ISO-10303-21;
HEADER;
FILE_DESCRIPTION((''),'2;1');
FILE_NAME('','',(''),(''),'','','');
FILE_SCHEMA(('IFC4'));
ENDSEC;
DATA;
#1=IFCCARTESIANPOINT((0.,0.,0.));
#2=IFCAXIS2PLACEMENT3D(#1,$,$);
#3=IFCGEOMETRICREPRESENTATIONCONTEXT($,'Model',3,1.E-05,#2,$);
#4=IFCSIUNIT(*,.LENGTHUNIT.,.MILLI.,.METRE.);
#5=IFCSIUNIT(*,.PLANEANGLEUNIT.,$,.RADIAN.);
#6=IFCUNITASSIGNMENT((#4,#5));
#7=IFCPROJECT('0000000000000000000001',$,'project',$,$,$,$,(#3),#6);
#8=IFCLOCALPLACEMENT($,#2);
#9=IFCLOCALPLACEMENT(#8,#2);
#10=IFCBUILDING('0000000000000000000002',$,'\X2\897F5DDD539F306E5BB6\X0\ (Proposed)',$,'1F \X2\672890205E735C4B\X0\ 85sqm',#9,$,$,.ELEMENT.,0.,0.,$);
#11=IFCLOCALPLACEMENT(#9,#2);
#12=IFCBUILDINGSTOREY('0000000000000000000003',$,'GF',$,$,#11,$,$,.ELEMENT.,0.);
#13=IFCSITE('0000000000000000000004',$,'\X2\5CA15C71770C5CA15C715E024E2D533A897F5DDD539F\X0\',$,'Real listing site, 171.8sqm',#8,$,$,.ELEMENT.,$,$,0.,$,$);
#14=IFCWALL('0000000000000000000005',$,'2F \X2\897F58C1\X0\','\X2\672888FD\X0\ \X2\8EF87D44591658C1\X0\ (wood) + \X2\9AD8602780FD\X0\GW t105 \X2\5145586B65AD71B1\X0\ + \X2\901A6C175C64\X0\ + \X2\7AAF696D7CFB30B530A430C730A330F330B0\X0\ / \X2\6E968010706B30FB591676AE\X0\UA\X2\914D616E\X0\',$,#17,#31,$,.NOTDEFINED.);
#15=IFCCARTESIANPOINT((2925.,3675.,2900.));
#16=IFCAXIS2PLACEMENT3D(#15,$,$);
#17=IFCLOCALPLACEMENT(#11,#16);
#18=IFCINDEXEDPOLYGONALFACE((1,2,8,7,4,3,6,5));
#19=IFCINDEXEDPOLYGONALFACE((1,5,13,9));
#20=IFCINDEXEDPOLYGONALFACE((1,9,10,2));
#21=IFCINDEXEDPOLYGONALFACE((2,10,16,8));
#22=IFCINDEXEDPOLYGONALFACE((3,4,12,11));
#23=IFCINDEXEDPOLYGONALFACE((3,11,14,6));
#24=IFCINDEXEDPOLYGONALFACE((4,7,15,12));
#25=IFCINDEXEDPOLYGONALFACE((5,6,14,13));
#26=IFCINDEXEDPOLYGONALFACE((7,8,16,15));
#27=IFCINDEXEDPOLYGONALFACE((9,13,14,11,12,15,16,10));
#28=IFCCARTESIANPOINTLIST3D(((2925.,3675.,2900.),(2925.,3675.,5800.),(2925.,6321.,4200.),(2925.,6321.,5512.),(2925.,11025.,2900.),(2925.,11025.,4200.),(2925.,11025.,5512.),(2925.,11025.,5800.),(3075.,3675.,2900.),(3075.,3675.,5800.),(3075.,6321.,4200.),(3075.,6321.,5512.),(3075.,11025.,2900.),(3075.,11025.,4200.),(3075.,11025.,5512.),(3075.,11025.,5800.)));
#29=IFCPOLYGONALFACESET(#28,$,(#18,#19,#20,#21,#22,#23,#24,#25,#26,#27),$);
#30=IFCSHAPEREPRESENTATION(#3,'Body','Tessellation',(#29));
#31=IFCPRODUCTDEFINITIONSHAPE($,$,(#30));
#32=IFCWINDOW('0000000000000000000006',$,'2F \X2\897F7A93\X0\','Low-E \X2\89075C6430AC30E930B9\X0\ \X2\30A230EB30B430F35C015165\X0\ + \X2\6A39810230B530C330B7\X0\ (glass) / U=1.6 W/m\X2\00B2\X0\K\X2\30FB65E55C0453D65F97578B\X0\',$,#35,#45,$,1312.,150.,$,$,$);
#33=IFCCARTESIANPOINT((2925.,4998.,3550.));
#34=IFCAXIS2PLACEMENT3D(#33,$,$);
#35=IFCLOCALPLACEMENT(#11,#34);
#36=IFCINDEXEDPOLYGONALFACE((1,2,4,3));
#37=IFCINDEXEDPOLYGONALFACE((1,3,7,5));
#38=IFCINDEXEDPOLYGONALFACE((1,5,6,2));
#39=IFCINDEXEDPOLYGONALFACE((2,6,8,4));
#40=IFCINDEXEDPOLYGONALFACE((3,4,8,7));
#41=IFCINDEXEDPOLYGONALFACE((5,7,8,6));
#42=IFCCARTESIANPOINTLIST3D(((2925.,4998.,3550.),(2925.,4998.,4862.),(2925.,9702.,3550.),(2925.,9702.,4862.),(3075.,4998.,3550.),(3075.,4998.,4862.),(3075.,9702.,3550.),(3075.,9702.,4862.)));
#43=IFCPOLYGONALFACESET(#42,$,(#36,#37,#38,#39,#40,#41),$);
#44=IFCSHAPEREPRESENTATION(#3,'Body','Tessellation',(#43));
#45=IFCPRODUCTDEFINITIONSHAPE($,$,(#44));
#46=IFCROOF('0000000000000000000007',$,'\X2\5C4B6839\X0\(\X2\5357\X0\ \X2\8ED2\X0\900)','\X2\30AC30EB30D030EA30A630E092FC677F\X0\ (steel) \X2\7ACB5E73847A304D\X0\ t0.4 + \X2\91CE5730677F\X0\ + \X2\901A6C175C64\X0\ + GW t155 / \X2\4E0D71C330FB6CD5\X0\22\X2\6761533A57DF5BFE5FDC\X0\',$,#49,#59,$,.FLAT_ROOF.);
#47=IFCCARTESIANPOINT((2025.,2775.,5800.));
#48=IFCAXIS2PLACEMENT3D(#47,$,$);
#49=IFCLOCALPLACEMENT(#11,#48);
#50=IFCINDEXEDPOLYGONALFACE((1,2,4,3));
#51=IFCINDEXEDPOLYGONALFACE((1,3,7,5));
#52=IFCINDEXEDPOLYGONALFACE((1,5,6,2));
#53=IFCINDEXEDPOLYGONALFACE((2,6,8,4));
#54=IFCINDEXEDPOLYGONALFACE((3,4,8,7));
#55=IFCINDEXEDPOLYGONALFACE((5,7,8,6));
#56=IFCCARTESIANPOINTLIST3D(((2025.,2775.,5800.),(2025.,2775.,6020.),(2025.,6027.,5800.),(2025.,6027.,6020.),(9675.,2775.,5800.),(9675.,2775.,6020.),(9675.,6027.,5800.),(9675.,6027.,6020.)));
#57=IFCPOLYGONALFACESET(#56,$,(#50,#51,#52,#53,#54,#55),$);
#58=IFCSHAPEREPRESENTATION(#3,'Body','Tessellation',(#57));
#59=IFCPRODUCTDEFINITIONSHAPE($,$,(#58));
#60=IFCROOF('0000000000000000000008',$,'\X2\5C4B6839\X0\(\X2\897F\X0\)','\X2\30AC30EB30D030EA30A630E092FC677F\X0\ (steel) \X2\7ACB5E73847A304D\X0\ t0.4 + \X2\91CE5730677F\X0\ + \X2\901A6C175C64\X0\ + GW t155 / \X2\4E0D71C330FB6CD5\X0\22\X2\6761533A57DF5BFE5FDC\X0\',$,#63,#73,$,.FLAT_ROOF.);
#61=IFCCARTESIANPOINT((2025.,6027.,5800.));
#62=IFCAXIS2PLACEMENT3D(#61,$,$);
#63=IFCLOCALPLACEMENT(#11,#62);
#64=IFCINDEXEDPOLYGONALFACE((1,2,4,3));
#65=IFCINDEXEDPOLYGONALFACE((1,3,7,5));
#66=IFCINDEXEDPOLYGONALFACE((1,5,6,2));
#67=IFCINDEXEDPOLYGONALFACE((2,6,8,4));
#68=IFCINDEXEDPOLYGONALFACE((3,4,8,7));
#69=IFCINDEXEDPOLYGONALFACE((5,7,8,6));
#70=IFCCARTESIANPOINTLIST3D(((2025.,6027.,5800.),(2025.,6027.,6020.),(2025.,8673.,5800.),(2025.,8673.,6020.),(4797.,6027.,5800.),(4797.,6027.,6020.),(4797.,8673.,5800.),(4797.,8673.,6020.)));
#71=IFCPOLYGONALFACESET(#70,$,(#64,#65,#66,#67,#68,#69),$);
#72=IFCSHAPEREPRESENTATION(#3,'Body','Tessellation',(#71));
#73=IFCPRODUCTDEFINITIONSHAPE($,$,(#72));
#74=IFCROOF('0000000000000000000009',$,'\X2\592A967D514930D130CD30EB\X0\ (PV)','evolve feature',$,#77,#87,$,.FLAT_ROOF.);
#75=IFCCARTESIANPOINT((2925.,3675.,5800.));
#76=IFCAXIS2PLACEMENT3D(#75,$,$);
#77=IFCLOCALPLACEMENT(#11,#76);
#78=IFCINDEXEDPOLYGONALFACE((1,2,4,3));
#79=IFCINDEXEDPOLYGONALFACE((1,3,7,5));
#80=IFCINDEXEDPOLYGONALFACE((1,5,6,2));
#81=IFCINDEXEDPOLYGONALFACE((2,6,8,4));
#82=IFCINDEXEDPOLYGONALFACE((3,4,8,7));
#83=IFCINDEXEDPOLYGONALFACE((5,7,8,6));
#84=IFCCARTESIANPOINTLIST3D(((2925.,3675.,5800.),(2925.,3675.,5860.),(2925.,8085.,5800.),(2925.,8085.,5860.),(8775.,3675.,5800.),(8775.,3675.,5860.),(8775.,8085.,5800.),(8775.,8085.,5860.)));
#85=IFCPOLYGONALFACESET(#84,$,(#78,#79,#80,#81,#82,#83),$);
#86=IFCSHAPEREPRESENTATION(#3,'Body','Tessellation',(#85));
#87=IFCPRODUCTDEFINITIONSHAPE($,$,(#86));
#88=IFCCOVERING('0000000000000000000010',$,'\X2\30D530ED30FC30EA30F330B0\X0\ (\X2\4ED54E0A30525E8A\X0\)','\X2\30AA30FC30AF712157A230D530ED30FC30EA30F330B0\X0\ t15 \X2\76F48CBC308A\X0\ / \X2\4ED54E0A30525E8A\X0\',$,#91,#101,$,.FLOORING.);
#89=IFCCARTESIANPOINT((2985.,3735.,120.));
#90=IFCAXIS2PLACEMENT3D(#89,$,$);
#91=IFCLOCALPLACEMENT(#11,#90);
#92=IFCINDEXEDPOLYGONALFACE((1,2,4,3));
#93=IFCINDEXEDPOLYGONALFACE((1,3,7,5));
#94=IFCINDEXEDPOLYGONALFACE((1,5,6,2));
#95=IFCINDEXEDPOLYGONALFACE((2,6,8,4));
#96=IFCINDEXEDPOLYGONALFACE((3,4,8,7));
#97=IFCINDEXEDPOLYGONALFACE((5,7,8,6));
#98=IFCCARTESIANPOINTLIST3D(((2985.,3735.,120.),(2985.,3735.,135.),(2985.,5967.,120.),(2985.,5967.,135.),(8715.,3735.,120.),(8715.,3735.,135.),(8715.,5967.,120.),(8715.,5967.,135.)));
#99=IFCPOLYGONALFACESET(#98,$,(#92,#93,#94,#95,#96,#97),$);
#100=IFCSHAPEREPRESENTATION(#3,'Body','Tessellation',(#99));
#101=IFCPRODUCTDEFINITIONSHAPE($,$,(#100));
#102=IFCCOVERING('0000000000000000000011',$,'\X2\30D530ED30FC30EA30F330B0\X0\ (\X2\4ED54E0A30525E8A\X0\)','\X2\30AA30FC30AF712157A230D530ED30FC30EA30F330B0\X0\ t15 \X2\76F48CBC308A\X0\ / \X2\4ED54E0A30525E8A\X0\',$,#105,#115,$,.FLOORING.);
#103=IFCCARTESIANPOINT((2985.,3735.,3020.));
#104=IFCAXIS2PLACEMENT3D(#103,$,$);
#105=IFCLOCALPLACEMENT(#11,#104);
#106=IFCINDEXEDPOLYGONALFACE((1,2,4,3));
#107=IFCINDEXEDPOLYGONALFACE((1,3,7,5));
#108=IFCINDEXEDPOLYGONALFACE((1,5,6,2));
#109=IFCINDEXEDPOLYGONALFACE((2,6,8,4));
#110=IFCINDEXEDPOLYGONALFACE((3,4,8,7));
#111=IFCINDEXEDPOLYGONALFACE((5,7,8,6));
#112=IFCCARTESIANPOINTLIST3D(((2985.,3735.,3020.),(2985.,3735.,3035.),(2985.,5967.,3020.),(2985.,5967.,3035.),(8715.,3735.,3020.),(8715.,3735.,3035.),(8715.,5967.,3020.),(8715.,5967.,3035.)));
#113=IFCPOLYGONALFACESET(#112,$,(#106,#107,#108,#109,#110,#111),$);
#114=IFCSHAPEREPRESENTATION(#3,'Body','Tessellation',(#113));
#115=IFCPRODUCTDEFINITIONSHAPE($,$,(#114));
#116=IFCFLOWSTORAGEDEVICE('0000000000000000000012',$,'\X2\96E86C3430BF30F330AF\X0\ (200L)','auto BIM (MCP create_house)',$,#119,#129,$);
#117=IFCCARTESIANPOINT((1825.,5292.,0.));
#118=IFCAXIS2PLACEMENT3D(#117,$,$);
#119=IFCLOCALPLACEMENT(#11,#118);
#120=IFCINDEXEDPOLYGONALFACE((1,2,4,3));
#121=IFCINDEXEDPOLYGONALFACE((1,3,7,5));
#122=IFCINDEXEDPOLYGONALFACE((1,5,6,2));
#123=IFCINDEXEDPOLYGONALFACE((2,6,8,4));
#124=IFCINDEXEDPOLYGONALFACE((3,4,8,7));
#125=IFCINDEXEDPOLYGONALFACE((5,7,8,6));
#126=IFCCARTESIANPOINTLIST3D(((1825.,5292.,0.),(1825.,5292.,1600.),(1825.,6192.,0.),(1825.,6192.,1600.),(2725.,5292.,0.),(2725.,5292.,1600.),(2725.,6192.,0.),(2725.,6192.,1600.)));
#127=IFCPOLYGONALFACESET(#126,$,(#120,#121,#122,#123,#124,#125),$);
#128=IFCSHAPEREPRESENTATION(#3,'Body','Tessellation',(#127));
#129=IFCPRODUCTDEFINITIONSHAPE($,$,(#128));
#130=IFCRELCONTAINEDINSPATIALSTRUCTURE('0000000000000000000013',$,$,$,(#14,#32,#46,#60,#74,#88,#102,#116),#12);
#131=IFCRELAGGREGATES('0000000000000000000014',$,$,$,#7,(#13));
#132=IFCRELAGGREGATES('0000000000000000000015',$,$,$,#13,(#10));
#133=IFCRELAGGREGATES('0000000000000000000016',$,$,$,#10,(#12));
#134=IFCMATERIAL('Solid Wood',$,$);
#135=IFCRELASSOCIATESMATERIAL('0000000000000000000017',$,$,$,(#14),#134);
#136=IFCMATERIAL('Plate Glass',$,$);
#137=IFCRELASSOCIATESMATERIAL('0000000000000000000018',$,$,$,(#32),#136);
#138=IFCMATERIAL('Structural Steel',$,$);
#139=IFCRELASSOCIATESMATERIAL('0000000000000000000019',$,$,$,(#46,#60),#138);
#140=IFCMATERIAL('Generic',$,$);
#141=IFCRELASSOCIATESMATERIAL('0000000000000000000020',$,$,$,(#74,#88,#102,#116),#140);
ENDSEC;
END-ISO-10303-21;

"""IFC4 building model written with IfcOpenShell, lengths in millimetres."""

from ifc_helpers import new_model, si_unit, frame, frame_2d, origin, place, context, project, spatial, rectangle, extrude, material, element, fill, save


model = new_model("IFC4")

# Units and contexts
model_context = context("Model", 3, precision=1e-05, world=origin())
ifc_project = project(units=[si_unit("LENGTHUNIT", "METRE", prefix="MILLI"), si_unit("PLANEANGLEUNIT", "RADIAN")], contexts=[model_context])

# Site, building, storey
site_placement = place(None, origin())
site = spatial("IfcSite", under=ifc_project, at=site_placement, Name="岡山県岡山市中区西川原", ObjectType="Real listing site, 171.8sqm", CompositionType="ELEMENT", RefElevation=0.0)
building_placement = place(site_placement, origin())
building = spatial("IfcBuilding", under=site, at=building_placement, Name="西川原の家 (Proposed)", ObjectType="1F 木造平屋 85sqm", CompositionType="ELEMENT", ElevationOfRefHeight=0.0, ElevationOfTerrain=0.0)
storey_placement = place(building_placement, origin())
storey = spatial("IfcBuildingStorey", under=building, at=storey_placement, Name="GF", CompositionType="ELEMENT", Elevation=0.0)

# Shared definitions
ifc_material_1 = material(Name="Solid Wood")
ifc_material_2 = material(Name="Generic")

# Shared definitions
ifc_material_3 = material(Name="Plate Glass")

# Wall, opening, window
wall_1_placement = place(storey_placement, frame((2925.0, 3675.0, 2900.0)))
wall_1 = element("IfcWall", 1, at=wall_1_placement, inside=storey, material=ifc_material_1, Name="2F 西壁", Description="木製 軸組外壁 (wood) + 高性能GW t105 充填断熱 + 通気層 + 窯業系サイディング / 準耐火・外皮UA配慮", PredefinedType="NOTDEFINED", context=model_context, shape_type="SweptSolid", body=[
    extrude(rectangle(XDim=150.0, YDim=7350.0, at=frame_2d((75.0, 3675.0))), frame((2925.0, 3675.0, 2900.0)), (0.0, 0.0, 1.0), 2900.0),
])
opening_1_placement = place(storey_placement, frame((2925.0, 4998.0, 3550.0)))
opening_1 = element("IfcOpeningElement", 2, at=opening_1_placement, cuts=wall_1, PredefinedType="NOTDEFINED", context=model_context, shape_type="SweptSolid", body=[
    extrude(rectangle(XDim=150.0, YDim=4704.0, at=frame_2d((75.0, 2352.0))), frame((2925.0, 4998.0, 3550.0)), (0.0, 0.0, 1.0), 1312.0),
])
window_1_placement = place(storey_placement, frame((2925.0, 4998.0, 3550.0)))
window_1 = element("IfcWindow", 3, at=window_1_placement, inside=storey, material=ifc_material_3, Name="2F 西窓", Description="Low-E 複層ガラス アルゴン封入 + 樹脂サッシ (glass) / U=1.6 W/m²K・日射取得型", OverallHeight=1312.0, OverallWidth=150.0, context=model_context, shape_type="SweptSolid", body=[
    extrude(rectangle(XDim=150.0, YDim=4704.0, at=frame_2d((75.0, 2352.0))), frame((2925.0, 4998.0, 3550.0)), (0.0, 0.0, 1.0), 1312.0),
])
fill(opening_1, window_1)

# Roofs
ifc_material_4 = material(Name="Structural Steel")
roof_1_placement = place(storey_placement, frame((2025.0, 2775.0, 5800.0)))
element("IfcRoof", 4, at=roof_1_placement, inside=storey, material=ifc_material_4, Name="屋根(南 軒900)", Description="ガルバリウム鋼板 (steel) 立平葺き t0.4 + 野地板 + 通気層 + GW t155 / 不燃・法22条区域対応", PredefinedType="FLAT_ROOF", context=model_context, shape_type="SweptSolid", body=[
    extrude(rectangle(XDim=7650.0, YDim=3252.0, at=frame_2d((3825.0, 1626.0))), frame((2025.0, 2775.0, 5800.0)), (0.0, 0.0, 1.0), 220.0),
])
roof_2_placement = place(storey_placement, frame((2025.0, 6027.0, 5800.0)))
element("IfcRoof", 5, at=roof_2_placement, inside=storey, material=ifc_material_4, Name="屋根(西)", Description="ガルバリウム鋼板 (steel) 立平葺き t0.4 + 野地板 + 通気層 + GW t155 / 不燃・法22条区域対応", PredefinedType="FLAT_ROOF", context=model_context, shape_type="SweptSolid", body=[
    extrude(rectangle(XDim=2772.0, YDim=2646.0, at=frame_2d((1386.0, 1323.0))), frame((2025.0, 6027.0, 5800.0)), (0.0, 0.0, 1.0), 220.0),
])
roof_3_placement = place(storey_placement, frame((2925.0, 3675.0, 5800.0)))
element("IfcRoof", 6, at=roof_3_placement, inside=storey, material=ifc_material_2, Name="太陽光パネル (PV)", Description="evolve feature", PredefinedType="FLAT_ROOF", context=model_context, shape_type="SweptSolid", body=[
    extrude(rectangle(XDim=5850.0, YDim=4410.0, at=frame_2d((2925.0, 2205.0))), frame((2925.0, 3675.0, 5800.0)), (0.0, 0.0, 1.0), 60.0),
])

# Coverings
covering_1_placement = place(storey_placement, frame((2985.0, 3735.0, 120.0)))
element("IfcCovering", 7, at=covering_1_placement, inside=storey, material=ifc_material_2, Name="フローリング (仕上げ床)", Description="オーク無垢フローリング t15 直貼り / 仕上げ床", PredefinedType="FLOORING", context=model_context, shape_type="SweptSolid", body=[
    extrude(rectangle(XDim=5730.0, YDim=2232.0, at=frame_2d((2865.0, 1116.0))), frame((2985.0, 3735.0, 120.0)), (0.0, 0.0, 1.0), 15.0),
])
covering_2_placement = place(storey_placement, frame((2985.0, 3735.0, 3020.0)))
element("IfcCovering", 8, at=covering_2_placement, inside=storey, material=ifc_material_2, Name="フローリング (仕上げ床)", Description="オーク無垢フローリング t15 直貼り / 仕上げ床", PredefinedType="FLOORING", context=model_context, shape_type="SweptSolid", body=[
    extrude(rectangle(XDim=5730.0, YDim=2232.0, at=frame_2d((2865.0, 1116.0))), frame((2985.0, 3735.0, 3020.0)), (0.0, 0.0, 1.0), 15.0),
])

# Flow storage device
flow_storage_device_placement = place(storey_placement, frame((1825.0, 5292.0, 0.0)))
element("IfcFlowStorageDevice", 9, at=flow_storage_device_placement, inside=storey, material=ifc_material_2, Name="雨水タンク (200L)", Description="auto BIM (MCP create_house)", context=model_context, shape_type="SweptSolid", body=[
    extrude(rectangle(XDim=900.0, YDim=900.0, at=frame_2d((450.0, 450.0))), frame((1825.0, 5292.0, 0.0)), (0.0, 0.0, 1.0), 1600.0),
])

save(model, "model.ifc")
